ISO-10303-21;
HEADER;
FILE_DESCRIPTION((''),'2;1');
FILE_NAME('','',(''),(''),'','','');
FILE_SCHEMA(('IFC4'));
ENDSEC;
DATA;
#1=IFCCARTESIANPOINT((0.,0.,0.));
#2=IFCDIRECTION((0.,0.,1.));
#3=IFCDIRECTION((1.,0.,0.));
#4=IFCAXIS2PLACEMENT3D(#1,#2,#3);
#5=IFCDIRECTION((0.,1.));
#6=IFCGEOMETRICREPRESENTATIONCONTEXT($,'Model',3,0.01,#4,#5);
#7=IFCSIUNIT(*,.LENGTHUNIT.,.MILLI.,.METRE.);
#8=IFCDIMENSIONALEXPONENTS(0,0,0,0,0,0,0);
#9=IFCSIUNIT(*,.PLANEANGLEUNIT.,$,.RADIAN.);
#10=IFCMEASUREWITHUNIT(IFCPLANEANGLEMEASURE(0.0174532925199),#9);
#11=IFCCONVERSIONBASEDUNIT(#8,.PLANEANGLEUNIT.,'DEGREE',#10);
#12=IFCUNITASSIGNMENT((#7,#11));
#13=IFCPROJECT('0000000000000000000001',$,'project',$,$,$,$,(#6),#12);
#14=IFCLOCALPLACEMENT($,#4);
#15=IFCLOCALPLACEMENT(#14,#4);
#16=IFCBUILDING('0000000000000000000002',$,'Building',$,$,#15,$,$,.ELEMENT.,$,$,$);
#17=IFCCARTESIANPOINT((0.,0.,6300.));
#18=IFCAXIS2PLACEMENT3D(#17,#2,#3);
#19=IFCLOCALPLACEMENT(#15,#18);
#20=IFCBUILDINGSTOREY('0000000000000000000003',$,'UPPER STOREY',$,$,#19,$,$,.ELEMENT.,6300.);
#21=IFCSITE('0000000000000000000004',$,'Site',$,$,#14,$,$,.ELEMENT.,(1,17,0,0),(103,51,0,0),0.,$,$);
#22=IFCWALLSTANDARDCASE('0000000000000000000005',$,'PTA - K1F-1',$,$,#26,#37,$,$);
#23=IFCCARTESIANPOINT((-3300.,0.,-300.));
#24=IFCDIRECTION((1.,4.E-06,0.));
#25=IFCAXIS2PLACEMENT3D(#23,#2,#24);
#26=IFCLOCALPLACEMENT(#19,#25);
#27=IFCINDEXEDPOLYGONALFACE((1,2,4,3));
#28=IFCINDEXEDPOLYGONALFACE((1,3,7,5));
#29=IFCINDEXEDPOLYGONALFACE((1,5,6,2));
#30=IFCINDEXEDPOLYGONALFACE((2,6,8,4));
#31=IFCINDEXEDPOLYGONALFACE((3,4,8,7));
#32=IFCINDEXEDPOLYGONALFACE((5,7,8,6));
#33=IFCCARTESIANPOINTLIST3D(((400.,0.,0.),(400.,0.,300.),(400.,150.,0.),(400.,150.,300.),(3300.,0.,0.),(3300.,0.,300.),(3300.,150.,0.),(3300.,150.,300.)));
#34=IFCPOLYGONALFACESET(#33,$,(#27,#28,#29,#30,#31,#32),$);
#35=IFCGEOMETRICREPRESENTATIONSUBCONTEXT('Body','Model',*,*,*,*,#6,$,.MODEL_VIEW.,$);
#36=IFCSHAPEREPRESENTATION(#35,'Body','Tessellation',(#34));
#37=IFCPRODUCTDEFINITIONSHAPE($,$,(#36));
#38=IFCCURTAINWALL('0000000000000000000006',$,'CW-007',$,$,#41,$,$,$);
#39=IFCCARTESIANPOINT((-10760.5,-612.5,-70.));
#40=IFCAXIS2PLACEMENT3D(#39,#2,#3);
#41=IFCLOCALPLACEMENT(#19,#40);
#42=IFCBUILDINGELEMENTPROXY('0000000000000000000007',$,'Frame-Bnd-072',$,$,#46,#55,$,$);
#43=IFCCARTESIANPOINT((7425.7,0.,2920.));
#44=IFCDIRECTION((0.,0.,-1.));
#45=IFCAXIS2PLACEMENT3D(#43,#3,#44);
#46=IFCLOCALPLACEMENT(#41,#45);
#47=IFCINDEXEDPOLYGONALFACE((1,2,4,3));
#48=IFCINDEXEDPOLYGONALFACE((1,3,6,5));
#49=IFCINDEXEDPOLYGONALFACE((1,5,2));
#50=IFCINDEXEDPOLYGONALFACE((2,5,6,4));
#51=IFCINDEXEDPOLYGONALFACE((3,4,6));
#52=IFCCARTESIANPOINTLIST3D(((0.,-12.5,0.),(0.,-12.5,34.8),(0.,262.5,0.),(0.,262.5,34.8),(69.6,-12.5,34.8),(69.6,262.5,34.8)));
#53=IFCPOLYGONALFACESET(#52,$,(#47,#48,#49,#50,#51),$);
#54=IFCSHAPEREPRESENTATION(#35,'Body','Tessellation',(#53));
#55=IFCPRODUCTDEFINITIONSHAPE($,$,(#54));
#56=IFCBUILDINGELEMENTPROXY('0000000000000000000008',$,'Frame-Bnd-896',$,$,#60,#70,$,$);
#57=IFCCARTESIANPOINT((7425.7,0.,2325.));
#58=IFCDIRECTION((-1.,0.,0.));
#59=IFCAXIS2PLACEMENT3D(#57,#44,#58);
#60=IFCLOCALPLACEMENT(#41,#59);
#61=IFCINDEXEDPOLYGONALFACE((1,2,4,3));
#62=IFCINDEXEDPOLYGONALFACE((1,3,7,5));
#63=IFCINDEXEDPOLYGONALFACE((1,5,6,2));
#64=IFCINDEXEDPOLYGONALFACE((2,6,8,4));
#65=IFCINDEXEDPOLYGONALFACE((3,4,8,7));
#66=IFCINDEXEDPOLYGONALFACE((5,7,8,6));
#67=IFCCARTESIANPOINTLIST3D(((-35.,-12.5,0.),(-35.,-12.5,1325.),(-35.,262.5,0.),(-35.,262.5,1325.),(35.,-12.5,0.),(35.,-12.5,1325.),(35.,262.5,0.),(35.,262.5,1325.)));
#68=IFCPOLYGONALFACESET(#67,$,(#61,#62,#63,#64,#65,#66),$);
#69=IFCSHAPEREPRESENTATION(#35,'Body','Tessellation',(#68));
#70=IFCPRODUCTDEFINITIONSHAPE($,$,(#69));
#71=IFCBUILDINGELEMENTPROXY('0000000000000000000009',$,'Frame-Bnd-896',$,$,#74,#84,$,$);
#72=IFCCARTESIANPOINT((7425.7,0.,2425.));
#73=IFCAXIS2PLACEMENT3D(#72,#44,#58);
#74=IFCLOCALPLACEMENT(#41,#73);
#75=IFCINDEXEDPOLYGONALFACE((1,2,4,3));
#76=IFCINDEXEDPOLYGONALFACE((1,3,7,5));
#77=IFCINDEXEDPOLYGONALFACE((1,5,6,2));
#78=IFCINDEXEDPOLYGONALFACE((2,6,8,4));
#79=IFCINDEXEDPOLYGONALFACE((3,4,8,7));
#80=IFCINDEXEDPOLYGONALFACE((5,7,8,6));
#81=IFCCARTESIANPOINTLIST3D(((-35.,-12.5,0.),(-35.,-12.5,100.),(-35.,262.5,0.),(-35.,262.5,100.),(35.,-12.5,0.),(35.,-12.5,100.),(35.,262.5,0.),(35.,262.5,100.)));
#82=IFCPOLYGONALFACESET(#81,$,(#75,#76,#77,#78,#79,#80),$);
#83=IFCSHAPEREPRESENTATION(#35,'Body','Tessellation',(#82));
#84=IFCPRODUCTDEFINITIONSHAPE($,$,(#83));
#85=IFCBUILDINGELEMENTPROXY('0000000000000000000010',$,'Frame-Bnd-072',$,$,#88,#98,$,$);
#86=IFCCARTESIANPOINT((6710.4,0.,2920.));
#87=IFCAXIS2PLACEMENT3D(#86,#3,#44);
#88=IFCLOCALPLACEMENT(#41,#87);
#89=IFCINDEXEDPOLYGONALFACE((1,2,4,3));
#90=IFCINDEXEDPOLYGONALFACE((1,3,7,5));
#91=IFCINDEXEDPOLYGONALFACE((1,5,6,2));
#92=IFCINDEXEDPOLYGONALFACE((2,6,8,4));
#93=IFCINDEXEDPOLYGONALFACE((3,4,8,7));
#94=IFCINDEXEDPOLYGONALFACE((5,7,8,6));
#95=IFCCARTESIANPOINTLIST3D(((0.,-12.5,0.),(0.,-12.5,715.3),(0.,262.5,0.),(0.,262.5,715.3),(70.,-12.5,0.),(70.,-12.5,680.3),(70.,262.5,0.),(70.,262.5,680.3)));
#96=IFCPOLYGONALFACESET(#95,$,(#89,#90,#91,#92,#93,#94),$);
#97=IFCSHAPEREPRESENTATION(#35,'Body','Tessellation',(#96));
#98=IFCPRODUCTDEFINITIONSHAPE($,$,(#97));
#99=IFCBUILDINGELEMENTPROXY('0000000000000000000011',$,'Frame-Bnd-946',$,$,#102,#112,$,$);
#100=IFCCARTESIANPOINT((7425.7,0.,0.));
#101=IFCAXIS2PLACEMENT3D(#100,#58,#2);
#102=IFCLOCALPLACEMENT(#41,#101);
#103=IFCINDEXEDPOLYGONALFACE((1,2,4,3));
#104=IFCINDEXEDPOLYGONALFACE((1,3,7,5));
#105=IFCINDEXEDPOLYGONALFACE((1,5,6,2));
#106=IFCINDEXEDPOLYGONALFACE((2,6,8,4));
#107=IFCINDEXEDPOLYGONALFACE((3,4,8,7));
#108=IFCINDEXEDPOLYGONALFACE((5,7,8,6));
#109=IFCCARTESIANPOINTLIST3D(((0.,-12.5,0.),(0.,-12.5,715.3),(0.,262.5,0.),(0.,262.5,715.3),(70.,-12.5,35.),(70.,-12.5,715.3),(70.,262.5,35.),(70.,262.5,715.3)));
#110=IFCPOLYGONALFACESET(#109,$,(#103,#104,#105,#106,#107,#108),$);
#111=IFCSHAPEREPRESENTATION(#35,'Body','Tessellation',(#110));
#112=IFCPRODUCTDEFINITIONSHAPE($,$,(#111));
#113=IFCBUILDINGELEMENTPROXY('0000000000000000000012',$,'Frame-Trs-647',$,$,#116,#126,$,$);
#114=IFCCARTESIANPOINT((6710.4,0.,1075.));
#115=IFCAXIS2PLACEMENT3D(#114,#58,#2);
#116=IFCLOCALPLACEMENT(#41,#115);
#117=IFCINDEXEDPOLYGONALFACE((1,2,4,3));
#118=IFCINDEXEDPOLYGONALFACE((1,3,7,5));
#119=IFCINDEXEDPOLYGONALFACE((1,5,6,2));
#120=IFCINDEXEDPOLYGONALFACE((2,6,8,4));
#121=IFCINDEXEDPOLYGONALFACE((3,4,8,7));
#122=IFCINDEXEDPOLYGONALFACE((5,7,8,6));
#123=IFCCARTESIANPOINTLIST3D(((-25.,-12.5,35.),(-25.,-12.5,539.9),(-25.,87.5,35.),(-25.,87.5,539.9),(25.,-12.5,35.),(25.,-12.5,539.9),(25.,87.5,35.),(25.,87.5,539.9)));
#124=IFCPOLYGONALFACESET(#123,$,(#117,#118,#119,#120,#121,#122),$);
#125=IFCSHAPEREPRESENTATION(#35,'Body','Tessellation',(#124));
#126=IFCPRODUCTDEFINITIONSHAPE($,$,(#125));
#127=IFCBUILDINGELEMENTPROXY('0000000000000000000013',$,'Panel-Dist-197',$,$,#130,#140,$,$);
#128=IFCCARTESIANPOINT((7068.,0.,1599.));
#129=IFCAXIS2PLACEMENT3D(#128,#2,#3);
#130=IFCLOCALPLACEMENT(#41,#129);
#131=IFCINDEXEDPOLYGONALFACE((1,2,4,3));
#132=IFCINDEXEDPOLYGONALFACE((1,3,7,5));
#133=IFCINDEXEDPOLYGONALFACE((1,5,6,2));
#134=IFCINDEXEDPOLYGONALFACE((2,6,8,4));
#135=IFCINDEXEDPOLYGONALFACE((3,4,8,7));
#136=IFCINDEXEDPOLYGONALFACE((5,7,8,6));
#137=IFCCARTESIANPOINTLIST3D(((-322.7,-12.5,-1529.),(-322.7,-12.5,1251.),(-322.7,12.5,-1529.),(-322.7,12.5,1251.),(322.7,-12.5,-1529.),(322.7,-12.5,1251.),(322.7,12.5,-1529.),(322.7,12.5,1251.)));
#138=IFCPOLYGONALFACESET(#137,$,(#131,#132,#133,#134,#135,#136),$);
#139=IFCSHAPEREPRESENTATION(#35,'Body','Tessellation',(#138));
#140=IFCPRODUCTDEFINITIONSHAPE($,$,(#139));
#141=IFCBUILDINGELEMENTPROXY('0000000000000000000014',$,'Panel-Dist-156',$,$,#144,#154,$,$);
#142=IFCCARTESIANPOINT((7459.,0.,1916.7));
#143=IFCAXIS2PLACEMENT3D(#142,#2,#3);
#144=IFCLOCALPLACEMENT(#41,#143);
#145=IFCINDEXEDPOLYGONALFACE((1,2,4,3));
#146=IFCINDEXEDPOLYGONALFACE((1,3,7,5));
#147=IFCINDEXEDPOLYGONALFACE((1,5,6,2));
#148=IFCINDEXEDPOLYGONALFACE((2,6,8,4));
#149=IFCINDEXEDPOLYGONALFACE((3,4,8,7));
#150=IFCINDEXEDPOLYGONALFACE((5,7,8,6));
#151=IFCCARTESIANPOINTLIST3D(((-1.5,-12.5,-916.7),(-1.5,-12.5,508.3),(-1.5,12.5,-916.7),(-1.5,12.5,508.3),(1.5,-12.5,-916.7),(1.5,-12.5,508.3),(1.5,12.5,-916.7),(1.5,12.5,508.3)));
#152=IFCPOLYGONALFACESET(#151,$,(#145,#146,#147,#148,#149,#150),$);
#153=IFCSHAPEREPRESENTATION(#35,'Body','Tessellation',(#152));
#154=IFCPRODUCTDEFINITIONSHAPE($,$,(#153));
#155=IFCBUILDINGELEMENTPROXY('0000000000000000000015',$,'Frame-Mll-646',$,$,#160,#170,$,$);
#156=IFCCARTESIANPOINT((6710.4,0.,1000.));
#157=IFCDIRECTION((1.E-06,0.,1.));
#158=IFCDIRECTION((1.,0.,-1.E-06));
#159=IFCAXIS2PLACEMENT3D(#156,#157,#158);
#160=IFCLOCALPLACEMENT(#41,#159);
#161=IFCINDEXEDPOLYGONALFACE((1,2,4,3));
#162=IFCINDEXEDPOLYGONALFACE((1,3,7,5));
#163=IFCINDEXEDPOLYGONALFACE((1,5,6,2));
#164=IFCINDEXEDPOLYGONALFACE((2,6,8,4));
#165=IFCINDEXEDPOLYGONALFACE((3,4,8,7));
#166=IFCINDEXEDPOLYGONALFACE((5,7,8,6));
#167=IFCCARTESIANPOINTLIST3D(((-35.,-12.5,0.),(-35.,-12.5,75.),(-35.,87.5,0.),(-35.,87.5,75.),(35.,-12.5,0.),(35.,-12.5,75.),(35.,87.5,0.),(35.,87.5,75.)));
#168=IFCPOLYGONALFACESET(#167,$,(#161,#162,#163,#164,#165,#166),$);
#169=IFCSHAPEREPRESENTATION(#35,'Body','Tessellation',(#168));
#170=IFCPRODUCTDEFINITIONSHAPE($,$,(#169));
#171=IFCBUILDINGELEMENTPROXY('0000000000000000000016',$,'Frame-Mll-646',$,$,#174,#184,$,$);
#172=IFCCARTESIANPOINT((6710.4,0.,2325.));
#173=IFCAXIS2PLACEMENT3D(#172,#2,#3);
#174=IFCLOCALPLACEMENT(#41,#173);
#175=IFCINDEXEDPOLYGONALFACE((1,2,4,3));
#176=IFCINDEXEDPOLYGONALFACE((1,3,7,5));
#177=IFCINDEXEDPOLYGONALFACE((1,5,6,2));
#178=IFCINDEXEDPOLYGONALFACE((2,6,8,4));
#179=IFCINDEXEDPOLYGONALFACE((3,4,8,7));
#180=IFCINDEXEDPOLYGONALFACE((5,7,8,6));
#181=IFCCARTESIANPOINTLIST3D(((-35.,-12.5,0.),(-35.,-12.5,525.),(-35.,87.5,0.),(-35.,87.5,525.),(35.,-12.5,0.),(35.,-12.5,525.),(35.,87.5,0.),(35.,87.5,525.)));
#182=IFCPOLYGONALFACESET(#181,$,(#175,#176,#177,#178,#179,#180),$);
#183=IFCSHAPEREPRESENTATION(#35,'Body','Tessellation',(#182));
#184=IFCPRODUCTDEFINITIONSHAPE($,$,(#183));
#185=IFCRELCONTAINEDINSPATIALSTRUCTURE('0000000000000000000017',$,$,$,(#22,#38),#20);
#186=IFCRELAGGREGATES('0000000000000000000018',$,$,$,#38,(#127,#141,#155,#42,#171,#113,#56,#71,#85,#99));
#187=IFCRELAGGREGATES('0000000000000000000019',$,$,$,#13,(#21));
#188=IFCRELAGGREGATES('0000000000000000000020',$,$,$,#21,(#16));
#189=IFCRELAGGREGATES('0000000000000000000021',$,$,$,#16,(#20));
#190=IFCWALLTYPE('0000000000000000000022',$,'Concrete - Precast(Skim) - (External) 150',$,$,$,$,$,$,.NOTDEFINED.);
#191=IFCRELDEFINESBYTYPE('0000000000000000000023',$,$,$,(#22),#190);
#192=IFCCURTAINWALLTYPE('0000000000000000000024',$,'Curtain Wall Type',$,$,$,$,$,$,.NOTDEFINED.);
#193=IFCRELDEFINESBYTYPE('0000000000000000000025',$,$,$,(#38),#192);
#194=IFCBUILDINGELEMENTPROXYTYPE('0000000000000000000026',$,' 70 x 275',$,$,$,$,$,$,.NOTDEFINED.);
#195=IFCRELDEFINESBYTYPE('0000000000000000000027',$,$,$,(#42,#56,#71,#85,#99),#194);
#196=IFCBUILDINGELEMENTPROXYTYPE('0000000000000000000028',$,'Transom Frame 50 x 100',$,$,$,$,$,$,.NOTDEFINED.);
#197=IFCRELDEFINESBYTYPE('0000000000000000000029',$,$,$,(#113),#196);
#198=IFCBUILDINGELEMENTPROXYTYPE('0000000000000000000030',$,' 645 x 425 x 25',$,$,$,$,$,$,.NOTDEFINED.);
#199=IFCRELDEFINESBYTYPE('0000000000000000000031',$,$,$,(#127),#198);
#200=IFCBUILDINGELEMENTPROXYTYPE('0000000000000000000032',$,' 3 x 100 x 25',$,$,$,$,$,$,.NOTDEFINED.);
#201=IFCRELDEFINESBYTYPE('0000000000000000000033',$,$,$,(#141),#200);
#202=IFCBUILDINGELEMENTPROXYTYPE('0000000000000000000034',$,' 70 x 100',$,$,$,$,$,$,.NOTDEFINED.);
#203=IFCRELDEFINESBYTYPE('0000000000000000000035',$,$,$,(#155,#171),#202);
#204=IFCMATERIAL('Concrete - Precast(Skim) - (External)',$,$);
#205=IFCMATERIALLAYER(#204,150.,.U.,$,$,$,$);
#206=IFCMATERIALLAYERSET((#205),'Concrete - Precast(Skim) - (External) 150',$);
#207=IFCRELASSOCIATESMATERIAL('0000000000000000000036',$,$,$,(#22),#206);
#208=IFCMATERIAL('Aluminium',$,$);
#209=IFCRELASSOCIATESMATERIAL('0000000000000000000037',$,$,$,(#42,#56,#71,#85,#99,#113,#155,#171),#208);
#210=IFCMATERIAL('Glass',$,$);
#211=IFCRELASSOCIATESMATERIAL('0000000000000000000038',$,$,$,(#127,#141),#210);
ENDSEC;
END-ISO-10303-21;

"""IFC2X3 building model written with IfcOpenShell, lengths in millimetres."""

from ifc_helpers import new_model, entity, si_unit, converted_unit, direction, frame, origin_with_axes, origin_2d_with_axis, place, context, subcontext, project, spatial, polyline, rectangle, outline, extrude, clip, halfspace, material, layer, layer_set, layer_usage, type_object, element, aggregate, save


model = new_model("IFC2X3")

# Units and contexts
model_context = context("Model", 3, precision=0.01, world=origin_with_axes(), true_north=direction((0.0, 1.0)))
body_context = subcontext(model_context, "Body", "Model", "MODEL_VIEW")
ifc_project = project(units=[si_unit("LENGTHUNIT", "METRE", prefix="MILLI"), converted_unit("PLANEANGLEUNIT", "DEGREE", entity("IfcPlaneAngleMeasure", 0.0174532925199), si_unit("PLANEANGLEUNIT", "RADIAN"), dimensions=[0, 0, 0, 0, 0, 0, 0])], contexts=[model_context])

# Site, building, storey
site_placement = place(None, origin_with_axes())
site = spatial("IfcSite", under=ifc_project, at=site_placement, Name="Site", CompositionType="ELEMENT", RefLatitude=(1, 17, 0, 0), RefLongitude=(103, 51, 0, 0), RefElevation=0.0)
building_placement = place(site_placement, origin_with_axes())
building = spatial("IfcBuilding", under=site, at=building_placement, Name="Building", CompositionType="ELEMENT")
storey_placement = place(building_placement, frame((0.0, 0.0, 6300.0), z_axis=(0.0, 0.0, 1.0), x_axis=(1.0, 0.0, 0.0)))
storey = spatial("IfcBuildingStorey", under=building, at=storey_placement, Name="UPPER STOREY", CompositionType="ELEMENT", Elevation=6300.0)

# Wall, opening
ifc_material_1 = material(Name="Concrete - Precast(Skim) - (External)")
ifc_layer_1 = layer(ifc_material_1, 150.0, ventilated="UNKNOWN")
ifc_layer_set_1 = layer_set([ifc_layer_1], Name="Concrete - Precast(Skim) - (External) 150")
ifc_layer_usage_1 = layer_usage(ifc_layer_set_1, "AXIS2", "POSITIVE", 0.0)
wall_type_1 = type_object("IfcWallType", Name="Concrete - Precast(Skim) - (External) 150", PredefinedType="NOTDEFINED")
wall_1_placement = place(storey_placement, frame((-3300.0, 0.0, -300.0), z_axis=(0.0, 0.0, 1.0), x_axis=(1.0, 0.000004, 0.0)))
wall_1 = element("IfcWallStandardCase", 1, at=wall_1_placement, inside=storey, type_object=wall_type_1, material=ifc_layer_usage_1, Name="PTA - K1F-1", context=body_context, shape_type="SweptSolid", body=[
    extrude(outline(polyline([(400.0, 0.0), (3300.0, 0.0), (3300.0, 150.0), (400.0, 150.0), (400.0, 0.0)])), origin_with_axes(), (0.0, 0.0, 1.0), 3150.0),
])
opening_1_placement = place(wall_1_placement, frame((1850.0, 0.0, 300.0), z_axis=(0.0, 0.0, 1.0), x_axis=(1.0, 0.0, 0.0)))
element("IfcOpeningElement", 2, at=opening_1_placement, cuts=wall_1, context=body_context, shape_type="SweptSolid", body=[
    extrude(rectangle(XDim=2900.0, YDim=2850.0, at=origin_2d_with_axis()), frame((0.0, -150.0, 1425.0), z_axis=(0.000004, 1.0, 0.0), x_axis=(-1.0, 0.000004, 0.0)), (0.0, 0.0, 1.0), 450.0),
])

# Shared definitions
ifc_material_2 = material(Name="Glass")

# Curtain wall, building element proxies
curtain_wall_type = type_object("IfcCurtainWallType", Name="Curtain Wall Type", PredefinedType="NOTDEFINED")
curtain_wall_placement = place(storey_placement, frame((-10760.5, -612.5, -70.0), z_axis=(0.0, 0.0, 1.0), x_axis=(1.0, 0.0, 0.0)))
curtain_wall = element("IfcCurtainWall", 3, at=curtain_wall_placement, inside=storey, type_object=curtain_wall_type, Name="CW-007")
ifc_material_3 = material(Name="Aluminium")
building_element_proxy_type_1 = type_object("IfcBuildingElementProxyType", Name=" 70 x 275", PredefinedType="NOTDEFINED")
proxy_1_placement = place(curtain_wall_placement, frame((7425.7, 0.0, 2920.0), z_axis=(1.0, 0.0, 0.0), x_axis=(0.0, 0.0, -1.0)))
proxy_1 = element("IfcBuildingElementProxy", 4, at=proxy_1_placement, type_object=building_element_proxy_type_1, material=ifc_material_3, Name="Frame-Bnd-072", context=body_context, shape_type="Clipping", body=[
    clip(extrude(outline(polyline([(12.5, 69.6), (-262.5, 69.6), (-262.5, 0.0), (12.5, 0.0), (12.5, 69.6)])), frame((0.0, 0.0, 0.0), z_axis=(0.0, 0.0, 1.0), x_axis=(0.0, -1.0, 0.0)), (0.0, 0.0, 1.0), 34.8), halfspace(frame((0.0, 0.0, 0.0), z_axis=(-0.447214, 0.0, 0.894427), x_axis=(0.0, -1.0, 0.0)), True)),
])
proxy_2_placement = place(curtain_wall_placement, frame((7425.7, 0.0, 2325.0), z_axis=(0.0, 0.0, -1.0), x_axis=(-1.0, 0.0, 0.0)))
proxy_2 = element("IfcBuildingElementProxy", 5, at=proxy_2_placement, type_object=building_element_proxy_type_1, material=ifc_material_3, Name="Frame-Bnd-896", context=body_context, shape_type="SweptSolid", body=[
    extrude(outline(polyline([(-35.0, -262.5), (35.0, -262.5), (35.0, 12.5), (-35.0, 12.5), (-35.0, -262.5)])), frame((0.0, 0.0, 0.0), z_axis=(0.0, 0.0, 1.0), x_axis=(-1.0, 0.0, 0.0)), (0.0, 0.0, 1.0), 1325.0),
])
proxy_3_placement = place(curtain_wall_placement, frame((7425.7, 0.0, 2425.0), z_axis=(0.0, 0.0, -1.0), x_axis=(-1.0, 0.0, 0.0)))
proxy_3 = element("IfcBuildingElementProxy", 6, at=proxy_3_placement, type_object=building_element_proxy_type_1, material=ifc_material_3, Name="Frame-Bnd-896", context=body_context, shape_type="SweptSolid", body=[
    extrude(outline(polyline([(-35.0, -262.5), (35.0, -262.5), (35.0, 12.5), (-35.0, 12.5), (-35.0, -262.5)])), frame((0.0, 0.0, 0.0), z_axis=(0.0, 0.0, 1.0), x_axis=(-1.0, 0.0, 0.0)), (0.0, 0.0, 1.0), 100.0),
])
proxy_4_placement = place(curtain_wall_placement, frame((6710.4, 0.0, 2920.0), z_axis=(1.0, 0.0, 0.0), x_axis=(0.0, 0.0, -1.0)))
proxy_4 = element("IfcBuildingElementProxy", 7, at=proxy_4_placement, type_object=building_element_proxy_type_1, material=ifc_material_3, Name="Frame-Bnd-072", context=body_context, shape_type="Clipping", body=[
    clip(extrude(outline(polyline([(-262.5, 70.0), (-262.5, 0.0), (12.5, 0.0), (12.5, 70.0), (-262.5, 70.0)])), frame((0.0, 0.0, 0.0), z_axis=(0.0, 0.0, 1.0), x_axis=(0.0, -1.0, 0.0)), (0.0, 0.0, 1.0), 715.3), halfspace(frame((286.1, 0.0, 572.3), z_axis=(-0.447214, 0.0, -0.894427), x_axis=(0.0, 1.0, 0.0)), True)),
])
proxy_5_placement = place(curtain_wall_placement, frame((7425.7, 0.0, 0.0), z_axis=(-1.0, 0.0, 0.0), x_axis=(0.0, 0.0, 1.0)))
proxy_5 = element("IfcBuildingElementProxy", 8, at=proxy_5_placement, type_object=building_element_proxy_type_1, material=ifc_material_3, Name="Frame-Bnd-946", context=body_context, shape_type="Clipping", body=[
    clip(extrude(outline(polyline([(262.5, -70.0), (262.5, 0.0), (-12.5, 0.0), (-12.5, -70.0), (262.5, -70.0)])), frame((0.0, 0.0, 0.0), z_axis=(0.0, 0.0, 1.0), x_axis=(0.0, 1.0, 0.0)), (0.0, 0.0, 1.0), 715.3), halfspace(frame((0.0, 0.0, 0.0), z_axis=(-0.447214, 0.0, 0.894427), x_axis=(0.0, -1.0, 0.0)), True)),
])
building_element_proxy_type_2 = type_object("IfcBuildingElementProxyType", Name="Transom Frame 50 x 100", PredefinedType="NOTDEFINED")
proxy_6_placement = place(curtain_wall_placement, frame((6710.4, 0.0, 1075.0), z_axis=(-1.0, 0.0, 0.0), x_axis=(0.0, 0.0, 1.0)))
proxy_6 = element("IfcBuildingElementProxy", 9, at=proxy_6_placement, type_object=building_element_proxy_type_2, material=ifc_material_3, Name="Frame-Trs-647", context=body_context, shape_type="SweptSolid", body=[
    extrude(outline(polyline([(87.5, -25.0), (87.5, 25.0), (-12.5, 25.0), (-12.5, -25.0), (87.5, -25.0)])), frame((0.0, 0.0, 35.0), z_axis=(0.0, 0.0, 1.0), x_axis=(0.0, 1.0, 0.0)), (0.0, 0.0, 1.0), 504.9),
])
building_element_proxy_type_3 = type_object("IfcBuildingElementProxyType", Name=" 645 x 425 x 25", PredefinedType="NOTDEFINED")
proxy_7_placement = place(curtain_wall_placement, frame((7068.0, 0.0, 1599.0), z_axis=(0.0, 0.0, 1.0), x_axis=(1.0, 0.0, 0.0)))
proxy_7 = element("IfcBuildingElementProxy", 10, at=proxy_7_placement, type_object=building_element_proxy_type_3, material=ifc_material_2, Name="Panel-Dist-197", context=body_context, shape_type="SweptSolid", body=[
    extrude(outline(polyline([(-322.7, -1251.0), (322.7, -1251.0), (322.7, 1529.0), (-322.7, 1529.0), (-322.7, -1251.0)])), frame((0.0, -12.5, 0.0), z_axis=(0.0, 1.0, 0.0), x_axis=(1.0, 0.0, 0.0)), (0.0, 0.0, 1.0), 25.0),
])
building_element_proxy_type_4 = type_object("IfcBuildingElementProxyType", Name=" 3 x 100 x 25", PredefinedType="NOTDEFINED")
proxy_8_placement = place(curtain_wall_placement, frame((7459.0, 0.0, 1916.7), z_axis=(0.0, 0.0, 1.0), x_axis=(1.0, 0.0, 0.0)))
proxy_8 = element("IfcBuildingElementProxy", 11, at=proxy_8_placement, type_object=building_element_proxy_type_4, material=ifc_material_2, Name="Panel-Dist-156", context=body_context, shape_type="SweptSolid", body=[
    extrude(outline(polyline([(-1.5, -508.3), (1.5, -508.3), (1.5, 916.7), (-1.5, 916.7), (-1.5, -508.3)])), frame((0.0, -12.5, 0.0), z_axis=(0.0, 1.0, 0.0), x_axis=(1.0, 0.0, 0.0)), (0.0, 0.0, 1.0), 25.0),
])
building_element_proxy_type_5 = type_object("IfcBuildingElementProxyType", Name=" 70 x 100", PredefinedType="NOTDEFINED")
proxy_9_placement = place(curtain_wall_placement, frame((6710.4, 0.0, 1000.0), z_axis=(0.000001, 0.0, 1.0), x_axis=(1.0, 0.0, -0.000001)))
proxy_9 = element("IfcBuildingElementProxy", 12, at=proxy_9_placement, type_object=building_element_proxy_type_5, material=ifc_material_3, Name="Frame-Mll-646", context=body_context, shape_type="SweptSolid", body=[
    extrude(outline(polyline([(35.0, 87.5), (-35.0, 87.5), (-35.0, -12.5), (35.0, -12.5), (35.0, 87.5)])), frame((0.0, 0.0, 0.0), z_axis=(0.0, 0.0, 1.0), x_axis=(1.0, 0.0, 0.000001)), (0.0, 0.0, 1.0), 75.0),
])
proxy_10_placement = place(curtain_wall_placement, frame((6710.4, 0.0, 2325.0), z_axis=(0.0, 0.0, 1.0), x_axis=(1.0, 0.0, 0.0)))
proxy_10 = element("IfcBuildingElementProxy", 13, at=proxy_10_placement, type_object=building_element_proxy_type_5, material=ifc_material_3, Name="Frame-Mll-646", context=body_context, shape_type="SweptSolid", body=[
    extrude(outline(polyline([(35.0, 87.5), (-35.0, 87.5), (-35.0, -12.5), (35.0, -12.5), (35.0, 87.5)])), frame((0.0, 0.0, 0.0), z_axis=(0.0, 0.0, 1.0), x_axis=(1.0, 0.0, 0.0)), (0.0, 0.0, 1.0), 525.0),
])
aggregate(curtain_wall, [proxy_7, proxy_8, proxy_9, proxy_1, proxy_10, proxy_6, proxy_2, proxy_3, proxy_4, proxy_5])

save(model, "model.ifc")
